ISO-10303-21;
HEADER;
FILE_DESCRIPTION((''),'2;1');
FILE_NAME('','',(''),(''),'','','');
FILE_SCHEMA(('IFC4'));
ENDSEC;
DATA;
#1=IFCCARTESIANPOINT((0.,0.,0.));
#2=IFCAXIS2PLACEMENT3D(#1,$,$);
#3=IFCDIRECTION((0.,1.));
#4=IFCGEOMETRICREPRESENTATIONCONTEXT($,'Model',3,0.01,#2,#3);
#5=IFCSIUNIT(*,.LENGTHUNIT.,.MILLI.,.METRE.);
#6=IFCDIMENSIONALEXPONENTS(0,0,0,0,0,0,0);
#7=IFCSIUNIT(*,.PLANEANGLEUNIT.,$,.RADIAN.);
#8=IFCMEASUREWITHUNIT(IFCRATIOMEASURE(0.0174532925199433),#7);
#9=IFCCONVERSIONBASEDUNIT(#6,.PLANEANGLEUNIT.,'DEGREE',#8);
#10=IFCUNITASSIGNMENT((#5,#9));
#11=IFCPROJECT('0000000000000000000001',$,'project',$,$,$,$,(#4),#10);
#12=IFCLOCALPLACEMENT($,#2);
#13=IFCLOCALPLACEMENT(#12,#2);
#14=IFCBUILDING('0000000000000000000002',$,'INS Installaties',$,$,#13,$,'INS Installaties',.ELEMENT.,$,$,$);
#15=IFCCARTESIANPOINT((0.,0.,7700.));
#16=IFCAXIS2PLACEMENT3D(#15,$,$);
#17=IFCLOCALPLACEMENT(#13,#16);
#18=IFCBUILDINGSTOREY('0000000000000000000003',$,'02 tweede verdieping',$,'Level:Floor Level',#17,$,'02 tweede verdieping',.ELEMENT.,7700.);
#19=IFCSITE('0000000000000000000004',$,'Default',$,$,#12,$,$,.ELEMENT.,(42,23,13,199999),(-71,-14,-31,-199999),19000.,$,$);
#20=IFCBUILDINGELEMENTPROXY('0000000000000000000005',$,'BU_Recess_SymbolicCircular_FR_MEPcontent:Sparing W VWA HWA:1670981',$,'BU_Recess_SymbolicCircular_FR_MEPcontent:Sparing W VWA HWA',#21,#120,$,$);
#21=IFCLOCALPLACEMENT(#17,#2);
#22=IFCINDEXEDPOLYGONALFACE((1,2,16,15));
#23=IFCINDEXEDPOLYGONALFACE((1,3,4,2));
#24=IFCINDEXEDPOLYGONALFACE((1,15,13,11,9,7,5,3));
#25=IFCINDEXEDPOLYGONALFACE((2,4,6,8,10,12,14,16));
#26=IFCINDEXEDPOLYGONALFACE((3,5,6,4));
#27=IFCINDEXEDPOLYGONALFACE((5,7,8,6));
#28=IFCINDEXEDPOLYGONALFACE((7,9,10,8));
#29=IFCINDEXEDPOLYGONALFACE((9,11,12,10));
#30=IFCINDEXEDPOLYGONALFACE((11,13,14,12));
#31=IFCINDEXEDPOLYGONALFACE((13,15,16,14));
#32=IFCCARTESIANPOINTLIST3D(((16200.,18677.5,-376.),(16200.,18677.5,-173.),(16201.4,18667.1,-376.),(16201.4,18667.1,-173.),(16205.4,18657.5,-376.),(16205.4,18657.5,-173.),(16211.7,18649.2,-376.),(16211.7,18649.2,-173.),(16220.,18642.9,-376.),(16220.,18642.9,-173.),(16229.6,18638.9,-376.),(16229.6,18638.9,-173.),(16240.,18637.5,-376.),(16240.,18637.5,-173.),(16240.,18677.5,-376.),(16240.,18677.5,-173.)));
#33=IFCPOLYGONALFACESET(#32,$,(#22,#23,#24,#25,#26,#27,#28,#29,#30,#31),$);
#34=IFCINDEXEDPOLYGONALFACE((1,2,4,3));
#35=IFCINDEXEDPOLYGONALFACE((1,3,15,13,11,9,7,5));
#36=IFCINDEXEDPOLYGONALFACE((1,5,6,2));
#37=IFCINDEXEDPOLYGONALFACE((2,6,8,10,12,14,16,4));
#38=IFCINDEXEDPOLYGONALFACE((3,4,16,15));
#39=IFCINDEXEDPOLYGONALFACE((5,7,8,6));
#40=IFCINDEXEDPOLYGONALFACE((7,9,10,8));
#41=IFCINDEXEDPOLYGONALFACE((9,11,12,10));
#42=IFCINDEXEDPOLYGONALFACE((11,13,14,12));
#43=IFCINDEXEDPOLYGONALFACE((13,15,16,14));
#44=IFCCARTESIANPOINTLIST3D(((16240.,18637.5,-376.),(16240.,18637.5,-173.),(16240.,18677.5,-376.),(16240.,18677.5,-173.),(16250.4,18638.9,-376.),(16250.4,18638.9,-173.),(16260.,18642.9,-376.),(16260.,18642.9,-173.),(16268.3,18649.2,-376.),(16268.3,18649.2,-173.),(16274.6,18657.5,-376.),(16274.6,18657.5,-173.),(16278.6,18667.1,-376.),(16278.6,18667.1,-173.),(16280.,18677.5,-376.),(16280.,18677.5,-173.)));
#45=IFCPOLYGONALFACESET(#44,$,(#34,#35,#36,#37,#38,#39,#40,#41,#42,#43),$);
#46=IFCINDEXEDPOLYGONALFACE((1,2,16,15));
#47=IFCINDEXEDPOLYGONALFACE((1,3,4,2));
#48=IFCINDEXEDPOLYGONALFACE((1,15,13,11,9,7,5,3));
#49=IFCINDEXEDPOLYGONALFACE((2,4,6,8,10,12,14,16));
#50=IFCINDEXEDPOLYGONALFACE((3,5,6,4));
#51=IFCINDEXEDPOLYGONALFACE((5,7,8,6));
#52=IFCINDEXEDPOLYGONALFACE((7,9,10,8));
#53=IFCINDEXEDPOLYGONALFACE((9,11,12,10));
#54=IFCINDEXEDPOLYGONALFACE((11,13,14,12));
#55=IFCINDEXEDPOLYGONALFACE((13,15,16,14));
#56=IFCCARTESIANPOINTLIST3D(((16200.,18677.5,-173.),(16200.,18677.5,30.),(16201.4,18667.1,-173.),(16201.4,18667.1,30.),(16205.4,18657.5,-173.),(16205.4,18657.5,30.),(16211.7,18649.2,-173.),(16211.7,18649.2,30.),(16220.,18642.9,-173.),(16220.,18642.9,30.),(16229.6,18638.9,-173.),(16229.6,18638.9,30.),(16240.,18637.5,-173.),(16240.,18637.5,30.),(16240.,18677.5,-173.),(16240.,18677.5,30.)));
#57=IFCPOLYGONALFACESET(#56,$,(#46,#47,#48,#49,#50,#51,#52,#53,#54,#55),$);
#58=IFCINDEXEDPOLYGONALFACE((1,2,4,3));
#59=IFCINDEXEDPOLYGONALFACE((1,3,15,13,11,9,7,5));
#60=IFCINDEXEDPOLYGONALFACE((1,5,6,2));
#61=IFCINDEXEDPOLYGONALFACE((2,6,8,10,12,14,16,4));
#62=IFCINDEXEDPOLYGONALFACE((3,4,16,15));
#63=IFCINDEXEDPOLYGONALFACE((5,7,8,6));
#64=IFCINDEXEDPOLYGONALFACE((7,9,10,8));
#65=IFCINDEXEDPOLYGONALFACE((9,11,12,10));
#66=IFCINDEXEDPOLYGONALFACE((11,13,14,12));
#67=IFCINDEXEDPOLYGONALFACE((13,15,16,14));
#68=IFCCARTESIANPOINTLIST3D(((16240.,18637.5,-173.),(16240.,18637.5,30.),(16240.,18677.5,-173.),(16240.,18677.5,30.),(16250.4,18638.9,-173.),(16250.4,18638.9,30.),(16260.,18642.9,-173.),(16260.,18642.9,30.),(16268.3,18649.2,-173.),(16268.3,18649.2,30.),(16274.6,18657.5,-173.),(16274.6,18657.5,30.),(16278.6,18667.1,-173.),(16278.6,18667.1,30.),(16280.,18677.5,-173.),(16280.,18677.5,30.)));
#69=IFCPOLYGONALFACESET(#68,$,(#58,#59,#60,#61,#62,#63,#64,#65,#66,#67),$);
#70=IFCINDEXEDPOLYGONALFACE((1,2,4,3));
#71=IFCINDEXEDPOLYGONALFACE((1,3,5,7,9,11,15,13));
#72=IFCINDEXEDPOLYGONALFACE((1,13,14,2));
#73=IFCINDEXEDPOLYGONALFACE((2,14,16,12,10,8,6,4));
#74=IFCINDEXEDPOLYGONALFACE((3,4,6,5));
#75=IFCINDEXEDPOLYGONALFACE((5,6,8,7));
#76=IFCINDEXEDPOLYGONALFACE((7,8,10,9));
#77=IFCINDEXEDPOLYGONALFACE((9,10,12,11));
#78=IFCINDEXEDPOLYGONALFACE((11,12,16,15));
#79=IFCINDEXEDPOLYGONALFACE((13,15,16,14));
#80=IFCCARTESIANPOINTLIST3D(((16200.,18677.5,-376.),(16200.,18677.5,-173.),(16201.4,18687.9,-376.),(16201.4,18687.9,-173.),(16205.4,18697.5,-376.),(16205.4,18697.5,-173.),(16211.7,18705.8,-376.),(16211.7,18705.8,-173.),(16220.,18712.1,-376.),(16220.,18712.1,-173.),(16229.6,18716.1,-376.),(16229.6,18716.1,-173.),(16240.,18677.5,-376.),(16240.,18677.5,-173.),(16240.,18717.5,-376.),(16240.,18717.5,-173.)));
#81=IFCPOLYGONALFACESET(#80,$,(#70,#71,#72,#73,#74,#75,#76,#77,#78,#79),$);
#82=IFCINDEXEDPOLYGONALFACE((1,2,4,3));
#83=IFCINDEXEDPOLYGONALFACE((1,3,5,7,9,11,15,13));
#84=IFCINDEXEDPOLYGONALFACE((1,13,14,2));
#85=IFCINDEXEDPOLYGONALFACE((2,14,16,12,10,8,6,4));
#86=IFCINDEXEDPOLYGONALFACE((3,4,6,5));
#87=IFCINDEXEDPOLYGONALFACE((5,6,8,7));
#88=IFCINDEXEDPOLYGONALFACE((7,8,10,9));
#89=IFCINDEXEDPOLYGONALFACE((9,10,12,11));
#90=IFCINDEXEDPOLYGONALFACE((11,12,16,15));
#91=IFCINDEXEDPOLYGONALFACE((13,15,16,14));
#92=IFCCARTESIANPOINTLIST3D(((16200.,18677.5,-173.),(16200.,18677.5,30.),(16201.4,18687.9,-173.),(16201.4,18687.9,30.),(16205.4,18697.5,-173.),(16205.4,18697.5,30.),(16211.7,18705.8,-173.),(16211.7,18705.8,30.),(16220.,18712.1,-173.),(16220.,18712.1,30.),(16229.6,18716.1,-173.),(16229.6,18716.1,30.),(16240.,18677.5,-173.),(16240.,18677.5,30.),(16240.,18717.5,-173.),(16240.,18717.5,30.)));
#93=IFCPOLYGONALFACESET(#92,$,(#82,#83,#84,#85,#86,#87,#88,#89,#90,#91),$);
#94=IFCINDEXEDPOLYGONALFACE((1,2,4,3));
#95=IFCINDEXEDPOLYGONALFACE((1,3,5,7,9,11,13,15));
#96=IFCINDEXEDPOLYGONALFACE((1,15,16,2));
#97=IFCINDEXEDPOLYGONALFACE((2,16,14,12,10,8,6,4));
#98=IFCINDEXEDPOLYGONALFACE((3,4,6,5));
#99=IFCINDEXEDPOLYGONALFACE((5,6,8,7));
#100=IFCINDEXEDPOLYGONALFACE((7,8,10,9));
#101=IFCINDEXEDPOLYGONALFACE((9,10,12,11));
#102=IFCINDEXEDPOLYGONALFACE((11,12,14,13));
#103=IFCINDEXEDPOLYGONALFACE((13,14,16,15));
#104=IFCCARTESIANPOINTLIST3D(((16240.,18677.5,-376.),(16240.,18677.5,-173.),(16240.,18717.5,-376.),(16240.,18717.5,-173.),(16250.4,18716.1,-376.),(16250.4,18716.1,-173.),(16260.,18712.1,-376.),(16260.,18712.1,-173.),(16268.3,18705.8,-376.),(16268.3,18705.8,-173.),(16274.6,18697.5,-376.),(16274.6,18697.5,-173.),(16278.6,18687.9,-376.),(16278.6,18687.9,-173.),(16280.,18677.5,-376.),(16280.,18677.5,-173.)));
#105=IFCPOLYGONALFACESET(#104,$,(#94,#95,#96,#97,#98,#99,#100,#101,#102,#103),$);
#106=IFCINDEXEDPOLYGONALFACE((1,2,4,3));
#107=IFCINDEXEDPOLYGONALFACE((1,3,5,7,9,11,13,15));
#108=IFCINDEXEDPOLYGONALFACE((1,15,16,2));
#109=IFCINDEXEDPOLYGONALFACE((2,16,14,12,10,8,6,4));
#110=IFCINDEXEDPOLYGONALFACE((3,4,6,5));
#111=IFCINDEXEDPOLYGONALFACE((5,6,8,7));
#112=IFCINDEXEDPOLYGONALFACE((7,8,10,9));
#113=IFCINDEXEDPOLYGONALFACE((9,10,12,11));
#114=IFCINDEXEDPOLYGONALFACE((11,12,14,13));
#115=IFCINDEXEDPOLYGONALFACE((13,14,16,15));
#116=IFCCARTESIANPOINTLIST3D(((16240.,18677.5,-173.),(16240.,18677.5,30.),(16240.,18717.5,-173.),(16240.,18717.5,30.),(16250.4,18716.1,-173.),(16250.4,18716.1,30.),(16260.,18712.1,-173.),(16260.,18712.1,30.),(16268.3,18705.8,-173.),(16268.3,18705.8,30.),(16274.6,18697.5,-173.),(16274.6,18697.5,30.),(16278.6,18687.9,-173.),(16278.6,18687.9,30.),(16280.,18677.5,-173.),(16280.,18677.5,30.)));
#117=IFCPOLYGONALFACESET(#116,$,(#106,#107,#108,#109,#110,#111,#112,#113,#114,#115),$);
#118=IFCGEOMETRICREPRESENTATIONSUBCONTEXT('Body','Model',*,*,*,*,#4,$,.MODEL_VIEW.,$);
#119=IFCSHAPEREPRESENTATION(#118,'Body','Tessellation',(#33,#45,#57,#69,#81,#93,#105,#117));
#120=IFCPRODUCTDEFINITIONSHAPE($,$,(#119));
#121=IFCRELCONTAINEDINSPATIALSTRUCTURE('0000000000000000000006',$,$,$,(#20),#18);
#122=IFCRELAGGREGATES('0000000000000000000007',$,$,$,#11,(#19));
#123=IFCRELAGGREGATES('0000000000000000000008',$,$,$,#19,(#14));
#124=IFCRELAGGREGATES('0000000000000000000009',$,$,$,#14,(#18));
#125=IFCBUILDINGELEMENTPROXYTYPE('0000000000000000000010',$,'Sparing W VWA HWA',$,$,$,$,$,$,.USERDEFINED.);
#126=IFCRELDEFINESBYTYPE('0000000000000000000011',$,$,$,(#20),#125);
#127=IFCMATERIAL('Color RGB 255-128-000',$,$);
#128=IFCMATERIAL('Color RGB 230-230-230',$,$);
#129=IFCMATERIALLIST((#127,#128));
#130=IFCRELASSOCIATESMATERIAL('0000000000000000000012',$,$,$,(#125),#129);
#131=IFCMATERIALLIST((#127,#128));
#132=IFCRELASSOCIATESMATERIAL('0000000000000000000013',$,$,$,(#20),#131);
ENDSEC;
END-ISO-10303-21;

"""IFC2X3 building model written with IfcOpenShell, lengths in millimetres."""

from ifc_helpers import new_model, entity, si_unit, converted_unit, direction, frame, frame_2d, origin, place, context, subcontext, project, spatial, polyline, circle_curve, parameter, trimmed, segment, composite_curve, outline, extrude, source, transform, mapped, material, material_list, type_object, type_shapes, element, save


model = new_model("IFC2X3")

# Units and contexts
model_context = context("Model", 3, precision=0.01, world=origin(), true_north=direction((0.0, 1.0)))
body_context = subcontext(model_context, "Body", "Model", "MODEL_VIEW")
ifc_project = project(units=[si_unit("LENGTHUNIT", "METRE", prefix="MILLI"), converted_unit("PLANEANGLEUNIT", "DEGREE", entity("IfcRatioMeasure", 0.0174532925199433), si_unit("PLANEANGLEUNIT", "RADIAN"), dimensions=[0, 0, 0, 0, 0, 0, 0])], contexts=[model_context])

# Site, building, storey
site_placement = place(None, origin())
site = spatial("IfcSite", under=ifc_project, at=site_placement, Name="Default", CompositionType="ELEMENT", RefLatitude=(42, 23, 13, 199999), RefLongitude=(-71, -14, -31, -199999), RefElevation=19000.0)
building_placement = place(site_placement, origin())
building = spatial("IfcBuilding", under=site, at=building_placement, Name="INS Installaties", LongName="INS Installaties", CompositionType="ELEMENT")
storey_placement = place(building_placement, frame((0.0, 0.0, 7700.0)))
storey = spatial("IfcBuildingStorey", under=building, at=storey_placement, Name="02 tweede verdieping", ObjectType="Level:Floor Level", LongName="02 tweede verdieping", CompositionType="ELEMENT", Elevation=7700.0)

# Building element proxy
ifc_material_1 = material(Name="Color RGB 255-128-000")
ifc_material_2 = material(Name="Color RGB 230-230-230")
ifc_material_list_1 = material_list([ifc_material_1, ifc_material_2])
building_element_proxy_type_1 = type_object("IfcBuildingElementProxyType", Name="Sparing W VWA HWA", PredefinedType="USERDEFINED", material=ifc_material_list_1)
shared_shape_1 = source(origin(), body_context, "Body", "SweptSolid", [
    extrude(outline(composite_curve([segment(trimmed(circle_curve(frame_2d((13.3, 13.3), x_axis=(1.0, 0.0)), 40.0), [parameter(180.0)], [parameter(270.0)], True, "PARAMETER"), True, "CONTINUOUS"), segment(polyline([(13.3, -26.7), (13.3, 13.3)]), True, "CONTINUOUS"), segment(polyline([(13.3, 13.3), (-26.7, 13.3)]), True, "CONTINUOUS")], self_intersect=False)), frame((13.3, 13.3, -403.0), z_axis=(0.0, 0.0, 1.0), x_axis=(-1.0, 0.0, 0.0)), (0.0, 0.0, 1.0), 203.0),
    extrude(outline(composite_curve([segment(polyline([(-26.7, -13.3), (13.3, -13.3)]), True, "CONTINUOUS"), segment(polyline([(13.3, -13.3), (13.3, 26.7)]), True, "CONTINUOUS"), segment(trimmed(circle_curve(frame_2d((13.3, -13.3), x_axis=(1.0, 0.0)), 40.0), [parameter(90.0)], [parameter(180.0)], True, "PARAMETER"), True, "CONTINUOUS")], self_intersect=False)), frame((-13.3, 13.3, -403.0)), (0.0, 0.0, 1.0), 203.0),
    extrude(outline(composite_curve([segment(trimmed(circle_curve(frame_2d((13.3, 13.3), x_axis=(1.0, 0.0)), 40.0), [parameter(180.0)], [parameter(270.0)], True, "PARAMETER"), True, "CONTINUOUS"), segment(polyline([(13.3, -26.7), (13.3, 13.3)]), True, "CONTINUOUS"), segment(polyline([(13.3, 13.3), (-26.7, 13.3)]), True, "CONTINUOUS")], self_intersect=False)), frame((13.3, 13.3, -200.0), z_axis=(0.0, 0.0, 1.0), x_axis=(-1.0, 0.0, 0.0)), (0.0, 0.0, 1.0), 203.0),
    extrude(outline(composite_curve([segment(polyline([(-26.7, -13.3), (13.3, -13.3)]), True, "CONTINUOUS"), segment(polyline([(13.3, -13.3), (13.3, 26.7)]), True, "CONTINUOUS"), segment(trimmed(circle_curve(frame_2d((13.3, -13.3), x_axis=(1.0, 0.0)), 40.0), [parameter(90.0)], [parameter(180.0)], True, "PARAMETER"), True, "CONTINUOUS")], self_intersect=False)), frame((-13.3, 13.3, -200.0)), (0.0, 0.0, 1.0), 203.0),
    extrude(outline(composite_curve([segment(polyline([(-26.7, -13.3), (13.3, -13.3)]), True, "CONTINUOUS"), segment(polyline([(13.3, -13.3), (13.3, 26.7)]), True, "CONTINUOUS"), segment(trimmed(circle_curve(frame_2d((13.3, -13.3), x_axis=(1.0, 0.0)), 40.0), [parameter(90.0)], [parameter(180.0)], True, "PARAMETER"), True, "CONTINUOUS")], self_intersect=False)), frame((13.3, -13.3, -403.0), z_axis=(0.0, 0.0, 1.0), x_axis=(-1.0, 0.0, 0.0)), (0.0, 0.0, 1.0), 203.0),
    extrude(outline(composite_curve([segment(polyline([(-26.7, -13.3), (13.3, -13.3)]), True, "CONTINUOUS"), segment(polyline([(13.3, -13.3), (13.3, 26.7)]), True, "CONTINUOUS"), segment(trimmed(circle_curve(frame_2d((13.3, -13.3), x_axis=(1.0, 0.0)), 40.0), [parameter(90.0)], [parameter(180.0)], True, "PARAMETER"), True, "CONTINUOUS")], self_intersect=False)), frame((13.3, -13.3, -200.0), z_axis=(0.0, 0.0, 1.0), x_axis=(-1.0, 0.0, 0.0)), (0.0, 0.0, 1.0), 203.0),
    extrude(outline(composite_curve([segment(trimmed(circle_curve(frame_2d((13.3, 13.3), x_axis=(1.0, 0.0)), 40.0), [parameter(180.0)], [parameter(270.0)], True, "PARAMETER"), True, "CONTINUOUS"), segment(polyline([(13.3, -26.7), (13.3, 13.3)]), True, "CONTINUOUS"), segment(polyline([(13.3, 13.3), (-26.7, 13.3)]), True, "CONTINUOUS")], self_intersect=False)), frame((-13.3, -13.3, -403.0)), (0.0, 0.0, 1.0), 203.0),
    extrude(outline(composite_curve([segment(trimmed(circle_curve(frame_2d((13.3, 13.3), x_axis=(1.0, 0.0)), 40.0), [parameter(180.0)], [parameter(270.0)], True, "PARAMETER"), True, "CONTINUOUS"), segment(polyline([(13.3, -26.7), (13.3, 13.3)]), True, "CONTINUOUS"), segment(polyline([(13.3, 13.3), (-26.7, 13.3)]), True, "CONTINUOUS")], self_intersect=False)), frame((-13.3, -13.3, -200.0)), (0.0, 0.0, 1.0), 203.0),
])
type_shapes(building_element_proxy_type_1, [shared_shape_1])
ifc_material_list_2 = material_list([ifc_material_1, ifc_material_2])
proxy_1_placement = place(storey_placement, frame((16240.0, 18677.5, 27.0), z_axis=(0.0, 0.0, 1.0), x_axis=(-1.0, 0.0, 0.0)))
element("IfcBuildingElementProxy", 1, at=proxy_1_placement, inside=storey, type_object=building_element_proxy_type_1, material=ifc_material_list_2, Name="BU_Recess_SymbolicCircular_FR_MEPcontent:Sparing W VWA HWA:1670981", ObjectType="BU_Recess_SymbolicCircular_FR_MEPcontent:Sparing W VWA HWA", context=body_context, shape_type="MappedRepresentation", body=[
    mapped(shared_shape_1, transform((0.0, 0.0, 0.0), scale=1.0)),
])

save(model, "model.ifc")
